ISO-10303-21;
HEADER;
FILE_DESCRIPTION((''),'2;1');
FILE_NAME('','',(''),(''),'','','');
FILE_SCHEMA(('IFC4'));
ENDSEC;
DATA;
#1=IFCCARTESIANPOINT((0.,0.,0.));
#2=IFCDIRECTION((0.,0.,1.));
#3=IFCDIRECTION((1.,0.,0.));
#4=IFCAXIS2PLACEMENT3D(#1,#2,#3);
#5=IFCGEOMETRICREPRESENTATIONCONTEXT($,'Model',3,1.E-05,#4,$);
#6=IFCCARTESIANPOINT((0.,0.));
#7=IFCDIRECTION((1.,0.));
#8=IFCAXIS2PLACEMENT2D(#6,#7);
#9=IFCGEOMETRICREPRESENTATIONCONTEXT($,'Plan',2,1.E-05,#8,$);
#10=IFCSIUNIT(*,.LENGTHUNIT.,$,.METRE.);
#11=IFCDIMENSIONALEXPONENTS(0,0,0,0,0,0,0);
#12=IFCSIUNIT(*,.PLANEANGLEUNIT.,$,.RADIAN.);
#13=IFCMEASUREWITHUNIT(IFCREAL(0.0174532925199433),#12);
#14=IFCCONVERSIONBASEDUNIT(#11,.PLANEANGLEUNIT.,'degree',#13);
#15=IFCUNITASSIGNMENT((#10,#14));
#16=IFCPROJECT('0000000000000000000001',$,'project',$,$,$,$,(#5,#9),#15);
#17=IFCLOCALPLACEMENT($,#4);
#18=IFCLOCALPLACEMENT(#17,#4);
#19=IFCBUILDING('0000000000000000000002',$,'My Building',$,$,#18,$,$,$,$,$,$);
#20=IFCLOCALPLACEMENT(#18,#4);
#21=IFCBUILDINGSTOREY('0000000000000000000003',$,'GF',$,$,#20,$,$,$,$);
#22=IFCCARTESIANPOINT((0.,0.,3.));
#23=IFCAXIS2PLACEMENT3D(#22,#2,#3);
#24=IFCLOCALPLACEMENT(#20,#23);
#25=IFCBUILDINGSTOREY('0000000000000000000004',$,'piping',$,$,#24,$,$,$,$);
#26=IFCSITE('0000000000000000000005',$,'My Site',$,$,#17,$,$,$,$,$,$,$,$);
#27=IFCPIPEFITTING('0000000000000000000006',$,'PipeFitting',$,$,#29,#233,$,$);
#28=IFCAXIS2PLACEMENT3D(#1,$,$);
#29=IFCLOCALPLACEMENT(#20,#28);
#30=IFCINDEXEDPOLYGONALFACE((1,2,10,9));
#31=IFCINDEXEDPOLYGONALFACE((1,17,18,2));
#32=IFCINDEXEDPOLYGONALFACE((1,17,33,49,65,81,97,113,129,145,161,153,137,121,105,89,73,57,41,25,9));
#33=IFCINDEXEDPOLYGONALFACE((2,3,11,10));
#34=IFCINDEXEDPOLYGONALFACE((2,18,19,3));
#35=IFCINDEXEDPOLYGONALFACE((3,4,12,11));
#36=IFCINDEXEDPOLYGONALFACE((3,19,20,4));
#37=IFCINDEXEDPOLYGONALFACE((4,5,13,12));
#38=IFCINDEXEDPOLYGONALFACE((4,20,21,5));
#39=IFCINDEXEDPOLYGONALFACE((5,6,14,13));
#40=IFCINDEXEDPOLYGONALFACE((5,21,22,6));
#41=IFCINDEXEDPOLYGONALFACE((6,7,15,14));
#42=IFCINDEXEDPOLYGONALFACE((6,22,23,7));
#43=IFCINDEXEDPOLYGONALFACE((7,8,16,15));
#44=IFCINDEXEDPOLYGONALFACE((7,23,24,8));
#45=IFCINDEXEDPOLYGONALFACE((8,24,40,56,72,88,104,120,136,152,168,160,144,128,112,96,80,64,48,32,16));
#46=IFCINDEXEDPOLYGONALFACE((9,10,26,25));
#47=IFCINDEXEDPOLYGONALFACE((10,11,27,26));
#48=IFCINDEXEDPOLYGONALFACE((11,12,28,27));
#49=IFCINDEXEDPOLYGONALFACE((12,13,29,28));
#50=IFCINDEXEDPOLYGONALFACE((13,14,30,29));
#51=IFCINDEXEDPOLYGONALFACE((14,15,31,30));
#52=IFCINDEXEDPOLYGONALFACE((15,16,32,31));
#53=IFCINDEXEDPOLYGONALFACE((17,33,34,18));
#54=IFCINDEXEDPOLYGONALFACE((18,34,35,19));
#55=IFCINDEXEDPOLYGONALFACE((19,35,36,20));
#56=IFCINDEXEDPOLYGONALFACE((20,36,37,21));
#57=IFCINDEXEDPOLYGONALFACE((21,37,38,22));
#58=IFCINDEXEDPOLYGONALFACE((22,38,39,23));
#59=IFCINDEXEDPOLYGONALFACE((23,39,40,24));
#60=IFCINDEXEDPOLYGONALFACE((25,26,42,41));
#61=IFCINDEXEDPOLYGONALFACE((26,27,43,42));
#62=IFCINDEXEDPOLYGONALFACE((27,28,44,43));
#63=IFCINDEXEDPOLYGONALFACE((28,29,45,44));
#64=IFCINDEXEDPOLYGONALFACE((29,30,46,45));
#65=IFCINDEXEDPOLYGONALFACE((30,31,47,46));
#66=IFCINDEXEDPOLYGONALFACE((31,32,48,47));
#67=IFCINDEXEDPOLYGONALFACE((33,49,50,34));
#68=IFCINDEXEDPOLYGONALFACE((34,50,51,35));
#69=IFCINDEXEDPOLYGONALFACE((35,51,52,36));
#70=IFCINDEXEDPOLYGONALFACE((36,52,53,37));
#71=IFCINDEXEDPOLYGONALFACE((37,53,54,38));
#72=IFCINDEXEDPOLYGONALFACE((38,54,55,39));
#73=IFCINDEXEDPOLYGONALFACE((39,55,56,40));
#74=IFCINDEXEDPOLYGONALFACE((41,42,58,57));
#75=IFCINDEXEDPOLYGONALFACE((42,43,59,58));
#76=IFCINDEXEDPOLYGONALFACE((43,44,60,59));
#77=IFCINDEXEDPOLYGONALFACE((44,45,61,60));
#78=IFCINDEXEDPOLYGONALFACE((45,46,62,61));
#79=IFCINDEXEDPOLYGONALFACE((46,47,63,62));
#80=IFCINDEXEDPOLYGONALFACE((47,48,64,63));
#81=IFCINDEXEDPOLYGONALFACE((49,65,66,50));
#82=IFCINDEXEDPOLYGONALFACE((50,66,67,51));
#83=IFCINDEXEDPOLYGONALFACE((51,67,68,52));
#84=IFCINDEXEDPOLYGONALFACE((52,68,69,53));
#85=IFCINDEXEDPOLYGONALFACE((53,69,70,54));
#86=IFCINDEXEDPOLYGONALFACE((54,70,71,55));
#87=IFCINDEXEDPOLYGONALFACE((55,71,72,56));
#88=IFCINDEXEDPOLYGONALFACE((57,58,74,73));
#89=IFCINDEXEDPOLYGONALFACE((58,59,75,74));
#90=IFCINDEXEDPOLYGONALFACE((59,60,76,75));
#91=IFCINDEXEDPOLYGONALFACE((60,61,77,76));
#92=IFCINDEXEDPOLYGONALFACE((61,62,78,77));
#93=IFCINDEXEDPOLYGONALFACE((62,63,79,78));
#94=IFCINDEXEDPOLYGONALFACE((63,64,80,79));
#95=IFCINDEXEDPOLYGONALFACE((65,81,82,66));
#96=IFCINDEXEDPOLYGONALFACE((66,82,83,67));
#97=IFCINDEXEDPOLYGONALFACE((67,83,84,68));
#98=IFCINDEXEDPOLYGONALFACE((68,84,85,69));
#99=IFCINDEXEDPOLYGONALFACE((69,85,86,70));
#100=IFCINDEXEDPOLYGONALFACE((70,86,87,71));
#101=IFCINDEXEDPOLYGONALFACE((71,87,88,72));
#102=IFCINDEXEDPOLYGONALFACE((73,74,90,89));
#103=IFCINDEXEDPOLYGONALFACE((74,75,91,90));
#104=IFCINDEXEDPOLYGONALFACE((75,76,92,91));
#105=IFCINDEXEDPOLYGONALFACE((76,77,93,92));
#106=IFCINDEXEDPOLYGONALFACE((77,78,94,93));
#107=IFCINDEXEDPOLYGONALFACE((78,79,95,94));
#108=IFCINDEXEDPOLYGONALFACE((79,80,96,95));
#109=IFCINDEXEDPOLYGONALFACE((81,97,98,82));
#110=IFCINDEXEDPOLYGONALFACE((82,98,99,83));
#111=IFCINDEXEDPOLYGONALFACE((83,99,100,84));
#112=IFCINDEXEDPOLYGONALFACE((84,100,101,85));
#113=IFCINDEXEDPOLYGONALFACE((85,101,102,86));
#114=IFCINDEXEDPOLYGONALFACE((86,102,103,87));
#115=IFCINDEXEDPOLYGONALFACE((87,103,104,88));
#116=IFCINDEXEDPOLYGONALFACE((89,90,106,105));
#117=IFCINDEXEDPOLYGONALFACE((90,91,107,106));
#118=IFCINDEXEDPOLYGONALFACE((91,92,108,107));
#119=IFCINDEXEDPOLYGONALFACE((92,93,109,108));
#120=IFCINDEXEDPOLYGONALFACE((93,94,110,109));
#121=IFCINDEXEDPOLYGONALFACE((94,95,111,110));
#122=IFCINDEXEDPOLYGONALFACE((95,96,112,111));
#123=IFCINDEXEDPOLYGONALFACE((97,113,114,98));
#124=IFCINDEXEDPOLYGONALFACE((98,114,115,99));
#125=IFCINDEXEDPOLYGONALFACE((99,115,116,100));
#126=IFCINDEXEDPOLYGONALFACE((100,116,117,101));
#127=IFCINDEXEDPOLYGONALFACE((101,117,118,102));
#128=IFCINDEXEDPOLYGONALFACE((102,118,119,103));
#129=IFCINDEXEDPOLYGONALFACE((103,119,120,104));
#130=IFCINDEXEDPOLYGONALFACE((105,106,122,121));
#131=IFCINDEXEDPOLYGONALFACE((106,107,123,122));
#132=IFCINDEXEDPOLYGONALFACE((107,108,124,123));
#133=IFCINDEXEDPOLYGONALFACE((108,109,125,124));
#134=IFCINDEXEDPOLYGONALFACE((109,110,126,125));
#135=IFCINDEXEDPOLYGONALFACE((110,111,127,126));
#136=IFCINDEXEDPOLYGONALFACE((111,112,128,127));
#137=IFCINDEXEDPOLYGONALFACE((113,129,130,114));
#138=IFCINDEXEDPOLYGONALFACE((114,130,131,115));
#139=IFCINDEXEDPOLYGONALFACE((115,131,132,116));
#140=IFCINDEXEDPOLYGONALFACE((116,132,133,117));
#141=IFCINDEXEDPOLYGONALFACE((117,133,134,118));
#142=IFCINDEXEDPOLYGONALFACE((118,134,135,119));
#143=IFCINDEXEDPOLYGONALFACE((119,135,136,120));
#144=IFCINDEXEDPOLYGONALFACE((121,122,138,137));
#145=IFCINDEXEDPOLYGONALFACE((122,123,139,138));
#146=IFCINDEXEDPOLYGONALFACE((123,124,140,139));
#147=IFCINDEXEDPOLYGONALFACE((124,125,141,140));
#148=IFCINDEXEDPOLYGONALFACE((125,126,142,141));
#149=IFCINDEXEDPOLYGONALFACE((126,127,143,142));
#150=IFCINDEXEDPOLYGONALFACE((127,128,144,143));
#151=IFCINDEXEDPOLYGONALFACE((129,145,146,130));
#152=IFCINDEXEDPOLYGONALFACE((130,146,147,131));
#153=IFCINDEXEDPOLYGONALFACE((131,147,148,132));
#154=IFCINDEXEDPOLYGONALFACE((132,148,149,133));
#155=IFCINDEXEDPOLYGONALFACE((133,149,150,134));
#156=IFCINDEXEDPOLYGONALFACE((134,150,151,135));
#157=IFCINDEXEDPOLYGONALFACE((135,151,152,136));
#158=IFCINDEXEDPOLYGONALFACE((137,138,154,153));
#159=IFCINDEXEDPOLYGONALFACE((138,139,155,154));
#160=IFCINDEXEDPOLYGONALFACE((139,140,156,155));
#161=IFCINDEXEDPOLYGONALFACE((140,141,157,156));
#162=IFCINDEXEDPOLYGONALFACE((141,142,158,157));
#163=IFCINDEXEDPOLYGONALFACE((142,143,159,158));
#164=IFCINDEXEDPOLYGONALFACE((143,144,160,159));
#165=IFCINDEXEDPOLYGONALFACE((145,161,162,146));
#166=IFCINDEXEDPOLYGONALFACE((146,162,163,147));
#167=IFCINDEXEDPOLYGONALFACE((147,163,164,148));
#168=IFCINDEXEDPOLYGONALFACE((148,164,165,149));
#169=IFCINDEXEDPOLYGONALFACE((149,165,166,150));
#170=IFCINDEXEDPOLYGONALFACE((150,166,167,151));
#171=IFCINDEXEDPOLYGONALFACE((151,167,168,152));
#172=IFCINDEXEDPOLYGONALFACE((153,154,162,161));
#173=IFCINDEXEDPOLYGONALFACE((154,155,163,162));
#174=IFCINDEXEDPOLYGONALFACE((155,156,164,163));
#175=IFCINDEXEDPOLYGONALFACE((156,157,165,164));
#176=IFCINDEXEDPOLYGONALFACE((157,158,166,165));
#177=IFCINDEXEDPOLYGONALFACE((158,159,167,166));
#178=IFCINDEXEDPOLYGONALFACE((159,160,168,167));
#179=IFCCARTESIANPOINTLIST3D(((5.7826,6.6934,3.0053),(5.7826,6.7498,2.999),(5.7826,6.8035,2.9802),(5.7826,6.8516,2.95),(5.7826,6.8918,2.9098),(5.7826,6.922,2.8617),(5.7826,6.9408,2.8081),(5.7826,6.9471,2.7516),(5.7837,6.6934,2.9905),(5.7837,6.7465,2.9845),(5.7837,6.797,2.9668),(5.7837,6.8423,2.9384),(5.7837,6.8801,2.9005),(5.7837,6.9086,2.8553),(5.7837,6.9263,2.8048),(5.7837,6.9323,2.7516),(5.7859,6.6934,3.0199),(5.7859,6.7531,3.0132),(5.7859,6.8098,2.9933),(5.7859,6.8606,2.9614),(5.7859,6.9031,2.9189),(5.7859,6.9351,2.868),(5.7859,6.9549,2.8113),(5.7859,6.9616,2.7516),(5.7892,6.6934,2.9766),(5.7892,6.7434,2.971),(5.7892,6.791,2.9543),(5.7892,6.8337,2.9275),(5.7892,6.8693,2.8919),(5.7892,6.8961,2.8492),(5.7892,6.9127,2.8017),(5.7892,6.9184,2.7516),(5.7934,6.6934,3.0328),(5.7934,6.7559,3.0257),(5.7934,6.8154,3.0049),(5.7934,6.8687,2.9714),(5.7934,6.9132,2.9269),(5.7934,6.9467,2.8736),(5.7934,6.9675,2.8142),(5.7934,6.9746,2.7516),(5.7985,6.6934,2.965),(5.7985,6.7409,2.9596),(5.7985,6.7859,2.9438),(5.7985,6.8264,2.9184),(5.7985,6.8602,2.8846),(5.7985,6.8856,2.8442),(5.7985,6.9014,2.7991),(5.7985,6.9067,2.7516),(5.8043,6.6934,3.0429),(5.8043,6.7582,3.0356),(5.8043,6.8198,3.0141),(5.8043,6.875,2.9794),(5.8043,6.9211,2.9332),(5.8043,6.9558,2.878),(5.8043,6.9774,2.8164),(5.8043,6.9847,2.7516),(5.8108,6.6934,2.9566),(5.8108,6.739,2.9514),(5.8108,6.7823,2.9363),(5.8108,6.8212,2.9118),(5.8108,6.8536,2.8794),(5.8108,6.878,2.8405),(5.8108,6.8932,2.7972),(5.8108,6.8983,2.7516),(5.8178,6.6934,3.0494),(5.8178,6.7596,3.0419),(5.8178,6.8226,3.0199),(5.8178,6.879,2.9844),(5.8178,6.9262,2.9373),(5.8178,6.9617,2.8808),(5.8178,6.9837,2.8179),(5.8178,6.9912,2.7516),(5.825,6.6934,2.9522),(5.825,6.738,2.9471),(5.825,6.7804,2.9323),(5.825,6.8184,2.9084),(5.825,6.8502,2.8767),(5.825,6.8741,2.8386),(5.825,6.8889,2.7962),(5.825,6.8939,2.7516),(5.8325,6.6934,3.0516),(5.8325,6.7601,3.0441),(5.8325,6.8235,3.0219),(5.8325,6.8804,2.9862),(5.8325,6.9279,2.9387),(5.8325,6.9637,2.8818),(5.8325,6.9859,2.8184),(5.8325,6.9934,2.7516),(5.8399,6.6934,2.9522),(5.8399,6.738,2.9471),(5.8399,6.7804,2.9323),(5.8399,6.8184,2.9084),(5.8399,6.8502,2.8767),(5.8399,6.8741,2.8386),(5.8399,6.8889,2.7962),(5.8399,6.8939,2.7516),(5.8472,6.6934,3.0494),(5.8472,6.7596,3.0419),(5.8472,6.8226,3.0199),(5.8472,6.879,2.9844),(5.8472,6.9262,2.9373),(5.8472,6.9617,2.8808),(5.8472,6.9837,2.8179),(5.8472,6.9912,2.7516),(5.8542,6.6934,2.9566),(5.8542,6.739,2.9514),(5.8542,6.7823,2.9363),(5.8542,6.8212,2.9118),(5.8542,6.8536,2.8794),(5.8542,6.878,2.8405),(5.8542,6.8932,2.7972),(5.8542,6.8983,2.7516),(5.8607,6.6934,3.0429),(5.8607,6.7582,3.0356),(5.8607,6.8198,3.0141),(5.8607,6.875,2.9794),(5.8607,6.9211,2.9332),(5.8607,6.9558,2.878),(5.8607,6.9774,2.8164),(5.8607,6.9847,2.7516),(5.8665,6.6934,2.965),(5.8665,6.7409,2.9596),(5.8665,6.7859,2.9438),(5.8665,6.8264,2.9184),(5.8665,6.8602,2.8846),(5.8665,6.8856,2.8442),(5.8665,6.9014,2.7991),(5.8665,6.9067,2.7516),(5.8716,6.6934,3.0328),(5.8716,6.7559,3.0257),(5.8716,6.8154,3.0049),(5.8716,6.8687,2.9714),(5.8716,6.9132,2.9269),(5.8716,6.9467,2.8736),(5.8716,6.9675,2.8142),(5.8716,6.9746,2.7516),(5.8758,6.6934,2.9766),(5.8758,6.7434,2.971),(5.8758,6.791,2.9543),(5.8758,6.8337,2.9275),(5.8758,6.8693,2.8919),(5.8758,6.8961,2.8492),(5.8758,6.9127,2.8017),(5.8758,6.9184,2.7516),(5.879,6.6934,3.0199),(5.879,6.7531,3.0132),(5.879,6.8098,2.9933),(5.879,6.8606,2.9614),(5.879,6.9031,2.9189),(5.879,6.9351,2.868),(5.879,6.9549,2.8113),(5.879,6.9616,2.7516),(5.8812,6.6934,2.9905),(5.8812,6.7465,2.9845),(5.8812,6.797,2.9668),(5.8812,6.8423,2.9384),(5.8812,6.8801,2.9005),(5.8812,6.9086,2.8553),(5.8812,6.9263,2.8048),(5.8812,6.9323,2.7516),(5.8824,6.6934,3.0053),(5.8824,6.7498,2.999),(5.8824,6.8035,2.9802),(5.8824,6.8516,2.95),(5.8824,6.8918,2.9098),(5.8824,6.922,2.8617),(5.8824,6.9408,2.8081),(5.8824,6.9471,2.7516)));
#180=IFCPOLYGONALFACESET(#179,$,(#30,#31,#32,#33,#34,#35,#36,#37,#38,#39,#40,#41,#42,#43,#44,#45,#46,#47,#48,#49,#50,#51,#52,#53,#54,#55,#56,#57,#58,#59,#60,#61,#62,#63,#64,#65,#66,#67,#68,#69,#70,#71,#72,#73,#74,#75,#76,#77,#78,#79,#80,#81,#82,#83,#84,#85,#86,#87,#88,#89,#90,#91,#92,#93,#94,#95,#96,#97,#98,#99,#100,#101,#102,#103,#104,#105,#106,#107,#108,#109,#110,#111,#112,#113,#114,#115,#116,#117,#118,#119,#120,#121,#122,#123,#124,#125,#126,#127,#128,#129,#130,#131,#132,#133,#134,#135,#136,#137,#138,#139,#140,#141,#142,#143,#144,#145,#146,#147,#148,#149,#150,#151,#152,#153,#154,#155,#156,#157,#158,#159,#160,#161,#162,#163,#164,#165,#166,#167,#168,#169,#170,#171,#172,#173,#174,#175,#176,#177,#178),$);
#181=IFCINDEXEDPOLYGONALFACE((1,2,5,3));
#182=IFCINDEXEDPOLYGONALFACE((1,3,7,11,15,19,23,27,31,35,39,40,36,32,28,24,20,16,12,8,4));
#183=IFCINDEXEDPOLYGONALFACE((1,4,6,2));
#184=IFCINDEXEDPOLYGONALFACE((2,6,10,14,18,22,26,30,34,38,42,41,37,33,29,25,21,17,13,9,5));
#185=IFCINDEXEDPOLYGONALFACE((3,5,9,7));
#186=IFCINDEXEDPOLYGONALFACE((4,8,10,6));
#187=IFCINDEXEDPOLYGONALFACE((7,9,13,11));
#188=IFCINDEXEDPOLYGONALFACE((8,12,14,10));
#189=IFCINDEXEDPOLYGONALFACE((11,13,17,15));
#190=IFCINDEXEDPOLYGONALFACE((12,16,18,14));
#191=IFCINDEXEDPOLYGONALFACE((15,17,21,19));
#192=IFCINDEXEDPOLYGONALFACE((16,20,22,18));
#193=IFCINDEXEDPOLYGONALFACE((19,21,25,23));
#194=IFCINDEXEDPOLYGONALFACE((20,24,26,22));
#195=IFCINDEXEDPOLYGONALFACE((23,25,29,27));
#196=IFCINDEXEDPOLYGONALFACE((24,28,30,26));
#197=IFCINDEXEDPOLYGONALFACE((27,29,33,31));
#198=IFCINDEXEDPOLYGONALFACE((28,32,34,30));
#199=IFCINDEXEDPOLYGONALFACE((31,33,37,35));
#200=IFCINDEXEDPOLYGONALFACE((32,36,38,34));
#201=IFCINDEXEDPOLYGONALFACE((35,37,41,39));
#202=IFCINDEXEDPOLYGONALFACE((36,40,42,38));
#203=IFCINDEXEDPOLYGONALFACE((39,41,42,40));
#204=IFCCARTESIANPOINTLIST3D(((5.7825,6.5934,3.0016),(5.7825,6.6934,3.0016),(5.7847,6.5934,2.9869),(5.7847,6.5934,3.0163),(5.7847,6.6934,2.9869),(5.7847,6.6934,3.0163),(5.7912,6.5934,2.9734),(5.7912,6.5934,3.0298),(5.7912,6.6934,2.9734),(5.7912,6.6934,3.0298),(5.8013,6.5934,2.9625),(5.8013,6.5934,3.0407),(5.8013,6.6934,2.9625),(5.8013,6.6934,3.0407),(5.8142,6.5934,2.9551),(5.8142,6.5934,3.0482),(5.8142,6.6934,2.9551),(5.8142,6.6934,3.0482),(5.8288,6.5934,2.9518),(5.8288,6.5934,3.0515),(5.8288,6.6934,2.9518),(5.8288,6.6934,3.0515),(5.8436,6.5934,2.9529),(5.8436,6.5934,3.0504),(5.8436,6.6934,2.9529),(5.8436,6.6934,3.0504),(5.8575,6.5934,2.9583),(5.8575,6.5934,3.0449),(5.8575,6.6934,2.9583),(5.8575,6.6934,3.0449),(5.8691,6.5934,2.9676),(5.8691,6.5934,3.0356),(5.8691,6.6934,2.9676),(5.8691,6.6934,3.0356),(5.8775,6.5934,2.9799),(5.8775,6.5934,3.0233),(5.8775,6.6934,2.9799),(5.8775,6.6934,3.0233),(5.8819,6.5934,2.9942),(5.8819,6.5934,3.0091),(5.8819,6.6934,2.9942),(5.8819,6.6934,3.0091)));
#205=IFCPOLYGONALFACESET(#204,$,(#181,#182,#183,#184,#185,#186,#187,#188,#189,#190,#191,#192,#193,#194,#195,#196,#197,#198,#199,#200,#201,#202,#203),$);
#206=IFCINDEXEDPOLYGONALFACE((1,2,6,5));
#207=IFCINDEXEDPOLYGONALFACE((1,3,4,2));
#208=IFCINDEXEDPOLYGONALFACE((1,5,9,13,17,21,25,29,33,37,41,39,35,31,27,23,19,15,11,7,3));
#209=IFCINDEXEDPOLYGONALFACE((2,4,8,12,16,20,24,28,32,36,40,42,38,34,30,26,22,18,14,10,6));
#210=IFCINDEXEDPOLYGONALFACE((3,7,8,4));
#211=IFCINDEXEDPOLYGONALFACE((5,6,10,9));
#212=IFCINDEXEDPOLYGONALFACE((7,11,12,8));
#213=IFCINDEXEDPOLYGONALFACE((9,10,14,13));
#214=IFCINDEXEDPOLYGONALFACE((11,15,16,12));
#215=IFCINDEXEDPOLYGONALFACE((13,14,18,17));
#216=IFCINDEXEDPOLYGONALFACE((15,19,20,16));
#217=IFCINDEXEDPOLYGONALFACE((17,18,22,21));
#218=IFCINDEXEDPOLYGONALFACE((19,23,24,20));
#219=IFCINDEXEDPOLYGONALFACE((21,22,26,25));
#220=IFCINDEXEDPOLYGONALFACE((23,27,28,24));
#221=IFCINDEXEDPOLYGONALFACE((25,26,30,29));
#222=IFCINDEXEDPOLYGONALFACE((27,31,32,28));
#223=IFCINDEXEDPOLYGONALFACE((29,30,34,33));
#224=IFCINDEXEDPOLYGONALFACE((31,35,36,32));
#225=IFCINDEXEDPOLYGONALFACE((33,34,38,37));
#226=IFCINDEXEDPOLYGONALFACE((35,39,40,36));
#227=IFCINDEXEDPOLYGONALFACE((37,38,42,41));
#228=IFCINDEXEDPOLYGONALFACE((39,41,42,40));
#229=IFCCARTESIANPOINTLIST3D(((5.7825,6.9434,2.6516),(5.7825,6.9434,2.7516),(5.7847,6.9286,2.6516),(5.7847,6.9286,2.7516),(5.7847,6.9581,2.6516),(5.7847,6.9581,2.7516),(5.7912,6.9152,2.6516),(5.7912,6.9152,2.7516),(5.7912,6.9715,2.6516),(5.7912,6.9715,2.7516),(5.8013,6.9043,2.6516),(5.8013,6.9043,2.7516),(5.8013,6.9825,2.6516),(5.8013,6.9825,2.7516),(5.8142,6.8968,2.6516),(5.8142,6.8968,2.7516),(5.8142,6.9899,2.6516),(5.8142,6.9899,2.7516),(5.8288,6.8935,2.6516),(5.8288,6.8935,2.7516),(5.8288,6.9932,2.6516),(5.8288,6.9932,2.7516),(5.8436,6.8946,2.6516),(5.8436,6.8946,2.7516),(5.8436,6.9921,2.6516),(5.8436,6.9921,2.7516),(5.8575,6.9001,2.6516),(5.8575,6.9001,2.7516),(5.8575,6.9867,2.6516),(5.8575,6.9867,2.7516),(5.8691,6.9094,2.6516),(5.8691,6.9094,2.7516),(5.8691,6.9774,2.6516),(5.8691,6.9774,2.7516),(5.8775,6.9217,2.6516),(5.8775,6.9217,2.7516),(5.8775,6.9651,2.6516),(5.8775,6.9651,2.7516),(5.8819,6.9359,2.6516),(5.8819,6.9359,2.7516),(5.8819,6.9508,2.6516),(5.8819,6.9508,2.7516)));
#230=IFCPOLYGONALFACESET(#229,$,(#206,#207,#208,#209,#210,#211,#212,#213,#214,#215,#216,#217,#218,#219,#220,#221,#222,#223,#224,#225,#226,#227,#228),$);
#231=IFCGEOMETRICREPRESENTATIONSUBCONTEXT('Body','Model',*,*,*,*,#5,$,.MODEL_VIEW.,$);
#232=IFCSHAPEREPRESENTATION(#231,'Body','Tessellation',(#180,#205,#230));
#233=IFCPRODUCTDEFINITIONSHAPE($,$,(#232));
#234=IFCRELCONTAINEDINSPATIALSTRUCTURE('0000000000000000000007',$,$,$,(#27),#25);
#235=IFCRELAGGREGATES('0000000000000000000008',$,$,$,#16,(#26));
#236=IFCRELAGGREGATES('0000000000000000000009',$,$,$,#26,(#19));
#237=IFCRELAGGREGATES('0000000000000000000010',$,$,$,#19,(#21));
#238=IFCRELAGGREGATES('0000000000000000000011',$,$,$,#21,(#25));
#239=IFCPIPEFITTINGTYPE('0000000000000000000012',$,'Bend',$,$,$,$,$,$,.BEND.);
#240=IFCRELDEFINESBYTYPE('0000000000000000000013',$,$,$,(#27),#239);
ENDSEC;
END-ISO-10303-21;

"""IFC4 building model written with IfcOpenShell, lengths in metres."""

from ifc_helpers import new_model, entity, si_unit, converted_unit, frame, origin_with_axes, origin_2d_with_axis, place, context, subcontext, project, spatial, circle, extrude, source, transform, mapped, type_object, type_shapes, element, save


model = new_model("IFC4")

# Units and contexts
model_context = context("Model", 3, precision=1e-05, world=origin_with_axes())
plan_context = context("Plan", 2, precision=1e-05, world=origin_2d_with_axis())
body_context = subcontext(model_context, "Body", "Model", "MODEL_VIEW")
ifc_project = project(units=[si_unit("LENGTHUNIT", "METRE"), converted_unit("PLANEANGLEUNIT", "degree", entity("IfcReal", 0.0174532925199433), si_unit("PLANEANGLEUNIT", "RADIAN"), dimensions=[0, 0, 0, 0, 0, 0, 0])], contexts=[model_context, plan_context])

# Site, building, storeys
site_placement = place(None, origin_with_axes())
site = spatial("IfcSite", under=ifc_project, at=site_placement, Name="My Site")
building_placement = place(site_placement, origin_with_axes())
building = spatial("IfcBuilding", under=site, at=building_placement, Name="My Building")
storey_1_placement = place(building_placement, origin_with_axes())
storey_1 = spatial("IfcBuildingStorey", under=building, at=storey_1_placement, Name="GF")
storey_2_placement = place(storey_1_placement, frame((0.0, 0.0, 3.0), z_axis=(0.0, 0.0, 1.0), x_axis=(1.0, 0.0, 0.0)))
storey_2 = spatial("IfcBuildingStorey", under=storey_1, at=storey_2_placement, Name="piping")

# Pipe fitting
pipe_fitting_type = type_object("IfcPipeFittingType", Name="Bend", PredefinedType="BEND")
shared_shape = source(origin_with_axes(), body_context, "Body", "SolidModel", [
    entity("IfcSweptDiskSolid", entity("IfcIndexedPolyCurve", entity("IfcCartesianPointList3D", [[0.0, 0.0, -0.1], [0.0, 0.0732, -0.2768], [0.0, 0.25, -0.35]]), [entity("IfcArcIndex", [1, 2, 3])]), 0.05),
    extrude(circle(Radius=0.05), origin_with_axes(), (0.0, 0.0, -1.0), 0.1),
    extrude(circle(Radius=0.05), frame((0.0, 0.25, -0.35), z_axis=(0.0, 1.0, 0.0), x_axis=(1.0, 0.0, 0.0)), (0.0, 0.0, 1.0), 0.1),
])
type_shapes(pipe_fitting_type, [shared_shape])
for number, where, z_axis, x_axis, name in (
    (1, (5.8325, 6.5934, 0.0016), (0.0, -1.0, 0.0), (-1.0, 0.0, 0.0), "PipeFitting"),
):
    element("IfcPipeFitting", number, at=place(storey_2_placement, frame(where, z_axis=z_axis, x_axis=x_axis)), inside=storey_2, type_object=pipe_fitting_type, Name=name, context=body_context, shape_type="MappedRepresentation", body=[
        mapped(shared_shape, transform((0.0, 0.0, 0.0), x_axis=(1.0, 0.0, 0.0), y_axis=(0.0, 1.0, 0.0), z_axis=(0.0, 0.0, 1.0), scale=1.0)),
    ])

save(model, "model.ifc")
